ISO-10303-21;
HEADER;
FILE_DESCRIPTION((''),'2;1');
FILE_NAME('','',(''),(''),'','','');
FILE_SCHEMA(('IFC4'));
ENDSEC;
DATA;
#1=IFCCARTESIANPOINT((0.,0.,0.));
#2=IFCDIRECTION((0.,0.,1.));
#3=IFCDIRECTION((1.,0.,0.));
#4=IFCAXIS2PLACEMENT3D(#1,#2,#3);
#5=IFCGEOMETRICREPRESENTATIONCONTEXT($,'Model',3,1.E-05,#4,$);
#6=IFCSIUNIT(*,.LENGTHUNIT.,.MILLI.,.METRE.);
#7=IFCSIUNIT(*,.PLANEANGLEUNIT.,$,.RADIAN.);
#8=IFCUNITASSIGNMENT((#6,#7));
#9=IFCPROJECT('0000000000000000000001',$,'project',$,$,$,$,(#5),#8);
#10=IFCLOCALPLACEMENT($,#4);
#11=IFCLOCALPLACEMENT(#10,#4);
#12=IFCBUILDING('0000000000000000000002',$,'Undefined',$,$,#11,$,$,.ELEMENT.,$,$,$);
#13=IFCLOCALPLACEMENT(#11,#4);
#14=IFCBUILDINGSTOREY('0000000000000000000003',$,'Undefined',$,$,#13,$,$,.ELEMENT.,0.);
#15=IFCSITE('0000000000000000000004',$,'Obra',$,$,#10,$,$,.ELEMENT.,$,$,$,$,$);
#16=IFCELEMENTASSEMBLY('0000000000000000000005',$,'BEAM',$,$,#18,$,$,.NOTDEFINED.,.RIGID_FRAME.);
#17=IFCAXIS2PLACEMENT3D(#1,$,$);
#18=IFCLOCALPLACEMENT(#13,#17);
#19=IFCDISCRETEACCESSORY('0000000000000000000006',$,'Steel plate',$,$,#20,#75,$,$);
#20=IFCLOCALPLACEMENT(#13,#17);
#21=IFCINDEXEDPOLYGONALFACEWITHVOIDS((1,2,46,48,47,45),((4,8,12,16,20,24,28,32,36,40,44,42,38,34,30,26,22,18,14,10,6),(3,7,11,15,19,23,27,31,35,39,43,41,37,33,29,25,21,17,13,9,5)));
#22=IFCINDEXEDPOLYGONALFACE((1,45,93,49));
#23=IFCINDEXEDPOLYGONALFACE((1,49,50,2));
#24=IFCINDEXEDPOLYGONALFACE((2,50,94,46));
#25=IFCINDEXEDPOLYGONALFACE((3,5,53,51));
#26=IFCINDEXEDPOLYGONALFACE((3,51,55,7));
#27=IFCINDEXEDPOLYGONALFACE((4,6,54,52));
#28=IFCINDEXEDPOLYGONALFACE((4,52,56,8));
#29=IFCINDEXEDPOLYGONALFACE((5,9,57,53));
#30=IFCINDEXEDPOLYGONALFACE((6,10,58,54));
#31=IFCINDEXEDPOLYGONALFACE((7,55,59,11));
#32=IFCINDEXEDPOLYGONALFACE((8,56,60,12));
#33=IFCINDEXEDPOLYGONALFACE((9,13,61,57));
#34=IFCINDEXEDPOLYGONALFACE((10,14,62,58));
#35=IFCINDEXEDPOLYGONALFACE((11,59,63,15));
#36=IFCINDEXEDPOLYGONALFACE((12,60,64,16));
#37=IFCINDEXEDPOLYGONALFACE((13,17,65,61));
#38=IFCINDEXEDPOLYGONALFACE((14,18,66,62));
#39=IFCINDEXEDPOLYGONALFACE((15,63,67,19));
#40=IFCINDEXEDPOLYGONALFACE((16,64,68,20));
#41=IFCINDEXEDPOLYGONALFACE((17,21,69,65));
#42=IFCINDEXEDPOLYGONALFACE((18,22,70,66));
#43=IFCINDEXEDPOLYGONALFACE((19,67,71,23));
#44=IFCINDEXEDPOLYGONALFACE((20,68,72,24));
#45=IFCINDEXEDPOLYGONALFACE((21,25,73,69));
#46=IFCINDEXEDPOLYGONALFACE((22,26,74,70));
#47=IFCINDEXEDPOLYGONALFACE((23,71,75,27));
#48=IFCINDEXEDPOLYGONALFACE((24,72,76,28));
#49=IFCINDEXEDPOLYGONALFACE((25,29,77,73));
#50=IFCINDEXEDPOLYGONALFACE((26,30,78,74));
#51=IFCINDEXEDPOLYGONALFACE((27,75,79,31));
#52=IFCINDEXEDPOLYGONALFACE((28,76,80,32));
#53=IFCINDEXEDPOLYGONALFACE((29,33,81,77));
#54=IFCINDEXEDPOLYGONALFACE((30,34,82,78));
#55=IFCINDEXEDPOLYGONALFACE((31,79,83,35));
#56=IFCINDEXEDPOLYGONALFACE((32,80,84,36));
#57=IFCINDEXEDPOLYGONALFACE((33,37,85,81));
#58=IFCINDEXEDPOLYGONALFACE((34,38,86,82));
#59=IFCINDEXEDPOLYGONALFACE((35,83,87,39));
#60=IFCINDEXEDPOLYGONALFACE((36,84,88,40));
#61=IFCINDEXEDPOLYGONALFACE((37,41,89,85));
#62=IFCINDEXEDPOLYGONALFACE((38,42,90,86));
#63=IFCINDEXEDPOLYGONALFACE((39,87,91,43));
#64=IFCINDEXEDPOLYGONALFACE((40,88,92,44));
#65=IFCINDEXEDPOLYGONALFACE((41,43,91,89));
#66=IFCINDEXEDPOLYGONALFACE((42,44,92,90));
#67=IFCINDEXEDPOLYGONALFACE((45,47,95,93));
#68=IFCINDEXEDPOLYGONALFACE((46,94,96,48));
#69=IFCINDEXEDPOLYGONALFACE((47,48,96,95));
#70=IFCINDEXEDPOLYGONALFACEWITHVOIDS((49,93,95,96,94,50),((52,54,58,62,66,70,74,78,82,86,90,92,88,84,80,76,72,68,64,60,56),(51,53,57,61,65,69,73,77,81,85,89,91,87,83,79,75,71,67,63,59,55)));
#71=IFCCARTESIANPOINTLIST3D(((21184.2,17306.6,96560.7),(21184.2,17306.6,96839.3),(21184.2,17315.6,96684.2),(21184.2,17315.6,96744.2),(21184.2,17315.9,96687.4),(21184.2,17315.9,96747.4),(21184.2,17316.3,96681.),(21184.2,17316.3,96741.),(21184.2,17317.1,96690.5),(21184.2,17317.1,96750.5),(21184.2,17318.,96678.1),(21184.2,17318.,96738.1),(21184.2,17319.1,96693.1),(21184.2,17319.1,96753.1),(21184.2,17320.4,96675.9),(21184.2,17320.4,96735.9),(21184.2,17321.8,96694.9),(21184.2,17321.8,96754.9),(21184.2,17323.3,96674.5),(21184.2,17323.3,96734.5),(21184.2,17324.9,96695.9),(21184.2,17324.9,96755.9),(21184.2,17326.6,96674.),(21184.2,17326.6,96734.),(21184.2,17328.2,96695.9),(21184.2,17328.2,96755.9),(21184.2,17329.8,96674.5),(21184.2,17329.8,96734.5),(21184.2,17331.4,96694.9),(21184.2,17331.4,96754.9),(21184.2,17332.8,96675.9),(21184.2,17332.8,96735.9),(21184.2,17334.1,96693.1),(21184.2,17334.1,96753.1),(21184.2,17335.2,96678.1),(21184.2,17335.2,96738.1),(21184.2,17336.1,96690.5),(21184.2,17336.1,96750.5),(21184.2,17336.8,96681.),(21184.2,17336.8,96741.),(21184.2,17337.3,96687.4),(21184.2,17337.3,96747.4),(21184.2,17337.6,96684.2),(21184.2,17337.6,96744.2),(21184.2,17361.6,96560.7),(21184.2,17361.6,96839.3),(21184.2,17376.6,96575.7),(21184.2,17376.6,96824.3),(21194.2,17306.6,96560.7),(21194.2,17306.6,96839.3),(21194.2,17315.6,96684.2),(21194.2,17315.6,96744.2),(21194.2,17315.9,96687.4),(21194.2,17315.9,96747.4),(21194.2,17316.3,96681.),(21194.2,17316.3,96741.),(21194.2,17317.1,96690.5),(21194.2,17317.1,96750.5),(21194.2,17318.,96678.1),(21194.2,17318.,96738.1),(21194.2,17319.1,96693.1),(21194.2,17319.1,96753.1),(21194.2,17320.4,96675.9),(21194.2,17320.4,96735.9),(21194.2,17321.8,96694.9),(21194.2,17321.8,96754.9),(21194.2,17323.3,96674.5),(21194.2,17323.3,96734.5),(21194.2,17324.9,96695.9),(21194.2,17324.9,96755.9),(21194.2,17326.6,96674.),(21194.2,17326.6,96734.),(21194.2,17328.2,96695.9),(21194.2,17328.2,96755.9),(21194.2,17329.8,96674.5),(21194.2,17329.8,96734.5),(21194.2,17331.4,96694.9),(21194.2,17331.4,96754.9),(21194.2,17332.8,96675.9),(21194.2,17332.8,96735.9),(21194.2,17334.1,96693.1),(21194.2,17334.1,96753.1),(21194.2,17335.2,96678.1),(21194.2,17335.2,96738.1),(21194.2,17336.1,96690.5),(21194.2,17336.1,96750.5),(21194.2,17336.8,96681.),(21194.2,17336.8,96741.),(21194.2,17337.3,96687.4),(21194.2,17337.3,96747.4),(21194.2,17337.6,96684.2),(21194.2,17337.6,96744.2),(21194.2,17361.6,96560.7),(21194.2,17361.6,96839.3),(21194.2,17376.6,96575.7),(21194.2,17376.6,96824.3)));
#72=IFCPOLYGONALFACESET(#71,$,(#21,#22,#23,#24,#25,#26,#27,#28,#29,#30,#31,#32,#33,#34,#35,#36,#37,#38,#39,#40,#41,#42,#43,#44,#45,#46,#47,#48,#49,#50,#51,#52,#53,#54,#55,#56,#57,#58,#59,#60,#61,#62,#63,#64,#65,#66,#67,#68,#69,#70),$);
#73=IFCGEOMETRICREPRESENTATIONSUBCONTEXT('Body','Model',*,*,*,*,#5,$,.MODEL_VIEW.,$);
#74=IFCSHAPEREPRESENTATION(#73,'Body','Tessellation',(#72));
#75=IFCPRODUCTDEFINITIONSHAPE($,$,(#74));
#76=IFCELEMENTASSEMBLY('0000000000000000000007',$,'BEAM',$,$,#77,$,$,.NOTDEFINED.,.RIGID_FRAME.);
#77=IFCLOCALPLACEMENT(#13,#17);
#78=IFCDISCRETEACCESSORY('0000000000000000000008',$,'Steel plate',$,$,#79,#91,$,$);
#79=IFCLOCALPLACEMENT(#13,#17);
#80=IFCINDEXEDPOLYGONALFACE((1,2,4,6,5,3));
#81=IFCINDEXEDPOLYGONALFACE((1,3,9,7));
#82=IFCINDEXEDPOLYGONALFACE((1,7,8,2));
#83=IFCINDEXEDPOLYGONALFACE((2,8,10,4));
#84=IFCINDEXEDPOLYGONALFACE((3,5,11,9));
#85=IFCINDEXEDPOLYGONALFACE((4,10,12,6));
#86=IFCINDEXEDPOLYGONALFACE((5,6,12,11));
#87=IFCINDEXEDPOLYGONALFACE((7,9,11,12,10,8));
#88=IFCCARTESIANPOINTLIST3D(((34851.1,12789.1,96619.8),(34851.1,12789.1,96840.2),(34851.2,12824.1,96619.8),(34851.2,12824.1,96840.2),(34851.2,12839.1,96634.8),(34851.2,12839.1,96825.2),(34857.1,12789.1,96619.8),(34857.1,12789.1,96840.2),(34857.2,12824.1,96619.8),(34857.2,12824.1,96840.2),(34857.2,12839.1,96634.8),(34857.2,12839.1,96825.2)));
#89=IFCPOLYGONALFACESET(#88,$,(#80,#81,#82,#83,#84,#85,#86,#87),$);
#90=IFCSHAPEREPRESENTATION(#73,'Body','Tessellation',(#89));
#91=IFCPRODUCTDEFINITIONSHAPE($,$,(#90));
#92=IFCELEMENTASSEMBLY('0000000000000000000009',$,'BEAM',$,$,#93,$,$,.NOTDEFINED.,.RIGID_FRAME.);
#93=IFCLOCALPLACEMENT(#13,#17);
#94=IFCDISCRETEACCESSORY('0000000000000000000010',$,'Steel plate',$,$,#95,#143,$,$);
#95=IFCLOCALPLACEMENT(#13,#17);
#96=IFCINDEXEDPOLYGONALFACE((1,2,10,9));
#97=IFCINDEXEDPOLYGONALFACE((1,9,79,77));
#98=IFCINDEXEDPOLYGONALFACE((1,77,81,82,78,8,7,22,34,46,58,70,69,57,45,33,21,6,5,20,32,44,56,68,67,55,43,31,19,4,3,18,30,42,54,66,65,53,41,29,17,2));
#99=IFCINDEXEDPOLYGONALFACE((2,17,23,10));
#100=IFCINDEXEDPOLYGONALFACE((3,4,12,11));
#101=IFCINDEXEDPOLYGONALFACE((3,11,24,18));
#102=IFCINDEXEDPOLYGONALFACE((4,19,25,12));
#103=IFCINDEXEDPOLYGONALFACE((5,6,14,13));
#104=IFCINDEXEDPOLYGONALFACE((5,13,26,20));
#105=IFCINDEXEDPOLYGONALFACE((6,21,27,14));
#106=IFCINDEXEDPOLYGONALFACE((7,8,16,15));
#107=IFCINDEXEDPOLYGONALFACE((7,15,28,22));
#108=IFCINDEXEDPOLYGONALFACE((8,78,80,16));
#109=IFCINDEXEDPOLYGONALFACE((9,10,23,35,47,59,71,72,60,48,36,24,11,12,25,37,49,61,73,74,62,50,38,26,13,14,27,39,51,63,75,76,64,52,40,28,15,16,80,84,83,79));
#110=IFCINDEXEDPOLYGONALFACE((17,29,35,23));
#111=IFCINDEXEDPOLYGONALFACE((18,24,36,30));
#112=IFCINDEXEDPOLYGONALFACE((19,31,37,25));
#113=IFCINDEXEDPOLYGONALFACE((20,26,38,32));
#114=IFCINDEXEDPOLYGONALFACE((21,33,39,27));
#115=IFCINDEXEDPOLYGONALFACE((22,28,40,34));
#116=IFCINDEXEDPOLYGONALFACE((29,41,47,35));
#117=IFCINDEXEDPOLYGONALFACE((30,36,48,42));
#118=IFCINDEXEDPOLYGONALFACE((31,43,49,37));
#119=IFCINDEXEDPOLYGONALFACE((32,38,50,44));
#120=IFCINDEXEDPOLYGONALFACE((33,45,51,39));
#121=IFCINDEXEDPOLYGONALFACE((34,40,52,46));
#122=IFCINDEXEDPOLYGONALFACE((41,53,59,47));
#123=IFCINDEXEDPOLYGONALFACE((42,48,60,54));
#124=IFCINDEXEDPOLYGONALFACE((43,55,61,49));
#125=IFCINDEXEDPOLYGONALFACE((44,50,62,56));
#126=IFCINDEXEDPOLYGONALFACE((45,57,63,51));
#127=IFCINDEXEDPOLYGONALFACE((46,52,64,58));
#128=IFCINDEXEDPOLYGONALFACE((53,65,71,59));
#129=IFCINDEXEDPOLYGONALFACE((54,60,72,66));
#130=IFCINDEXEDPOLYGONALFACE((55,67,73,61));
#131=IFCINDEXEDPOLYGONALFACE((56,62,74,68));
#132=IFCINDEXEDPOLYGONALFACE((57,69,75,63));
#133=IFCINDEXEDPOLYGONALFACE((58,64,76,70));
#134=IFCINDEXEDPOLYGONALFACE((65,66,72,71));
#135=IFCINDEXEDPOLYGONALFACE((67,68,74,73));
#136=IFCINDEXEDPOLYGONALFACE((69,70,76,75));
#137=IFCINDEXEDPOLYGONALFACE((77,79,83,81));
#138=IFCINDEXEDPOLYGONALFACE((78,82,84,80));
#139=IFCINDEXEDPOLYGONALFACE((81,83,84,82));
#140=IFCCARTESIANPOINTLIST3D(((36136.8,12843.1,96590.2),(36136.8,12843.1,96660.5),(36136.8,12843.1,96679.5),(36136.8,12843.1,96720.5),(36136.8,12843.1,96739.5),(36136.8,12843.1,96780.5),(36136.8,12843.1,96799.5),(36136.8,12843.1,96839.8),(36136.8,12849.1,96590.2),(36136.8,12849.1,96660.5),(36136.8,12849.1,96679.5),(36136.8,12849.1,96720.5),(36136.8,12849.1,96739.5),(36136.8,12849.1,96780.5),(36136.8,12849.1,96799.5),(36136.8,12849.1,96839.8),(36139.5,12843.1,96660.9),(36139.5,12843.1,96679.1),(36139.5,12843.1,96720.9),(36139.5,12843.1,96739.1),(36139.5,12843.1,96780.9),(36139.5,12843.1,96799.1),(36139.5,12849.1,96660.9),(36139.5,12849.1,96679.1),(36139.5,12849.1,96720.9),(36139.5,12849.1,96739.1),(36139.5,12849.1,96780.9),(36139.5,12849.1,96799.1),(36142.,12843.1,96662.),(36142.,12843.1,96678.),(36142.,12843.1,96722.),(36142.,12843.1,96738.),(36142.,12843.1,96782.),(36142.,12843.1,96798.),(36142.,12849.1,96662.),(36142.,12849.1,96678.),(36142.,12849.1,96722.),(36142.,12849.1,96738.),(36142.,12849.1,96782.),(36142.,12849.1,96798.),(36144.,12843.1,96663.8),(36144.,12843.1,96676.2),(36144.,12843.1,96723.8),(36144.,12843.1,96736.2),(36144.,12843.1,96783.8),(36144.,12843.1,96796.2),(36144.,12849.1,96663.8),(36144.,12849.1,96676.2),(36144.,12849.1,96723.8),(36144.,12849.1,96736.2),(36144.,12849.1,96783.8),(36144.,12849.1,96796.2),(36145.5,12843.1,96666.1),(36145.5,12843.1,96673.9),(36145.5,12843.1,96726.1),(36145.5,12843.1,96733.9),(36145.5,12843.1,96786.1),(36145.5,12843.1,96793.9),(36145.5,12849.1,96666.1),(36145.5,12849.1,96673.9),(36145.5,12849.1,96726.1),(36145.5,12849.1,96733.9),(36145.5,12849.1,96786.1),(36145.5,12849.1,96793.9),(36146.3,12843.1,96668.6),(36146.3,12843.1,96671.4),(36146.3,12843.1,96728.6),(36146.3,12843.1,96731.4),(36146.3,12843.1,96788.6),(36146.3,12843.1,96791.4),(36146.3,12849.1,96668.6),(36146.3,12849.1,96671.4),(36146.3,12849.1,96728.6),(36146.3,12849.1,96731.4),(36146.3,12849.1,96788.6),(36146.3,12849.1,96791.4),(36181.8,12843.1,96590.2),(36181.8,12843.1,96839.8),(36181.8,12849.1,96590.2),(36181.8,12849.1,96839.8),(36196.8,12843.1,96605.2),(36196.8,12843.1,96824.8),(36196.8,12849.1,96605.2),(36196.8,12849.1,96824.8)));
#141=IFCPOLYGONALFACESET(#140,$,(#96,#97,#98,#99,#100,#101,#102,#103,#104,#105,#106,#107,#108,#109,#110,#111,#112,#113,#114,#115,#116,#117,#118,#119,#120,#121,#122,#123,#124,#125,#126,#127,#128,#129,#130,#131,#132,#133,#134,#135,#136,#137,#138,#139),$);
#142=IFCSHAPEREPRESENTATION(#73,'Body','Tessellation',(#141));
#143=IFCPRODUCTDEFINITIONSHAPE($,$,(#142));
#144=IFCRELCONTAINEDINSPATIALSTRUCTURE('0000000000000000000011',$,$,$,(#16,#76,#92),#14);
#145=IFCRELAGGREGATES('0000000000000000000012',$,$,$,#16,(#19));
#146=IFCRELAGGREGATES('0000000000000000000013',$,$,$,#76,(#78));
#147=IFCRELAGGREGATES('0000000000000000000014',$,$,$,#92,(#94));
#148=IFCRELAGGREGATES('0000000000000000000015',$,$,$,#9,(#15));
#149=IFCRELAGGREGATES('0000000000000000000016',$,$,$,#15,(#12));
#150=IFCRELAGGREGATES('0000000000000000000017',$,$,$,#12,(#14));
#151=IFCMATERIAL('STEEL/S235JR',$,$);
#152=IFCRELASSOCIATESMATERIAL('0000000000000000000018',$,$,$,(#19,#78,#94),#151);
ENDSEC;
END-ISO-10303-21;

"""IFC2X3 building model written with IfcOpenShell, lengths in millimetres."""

from ifc_helpers import new_model, si_unit, frame, origin_with_axes, origin_2d_with_axis, place, context, subcontext, project, spatial, polyline, circle, outline, extrude, source, transform, mapped, material, element, aggregate, save


model = new_model("IFC2X3")

# Units and contexts
model_context = context("Model", 3, precision=1e-05, world=origin_with_axes())
body_context = subcontext(model_context, "Body", "Model", "MODEL_VIEW")
ifc_project = project(units=[si_unit("LENGTHUNIT", "METRE", prefix="MILLI"), si_unit("PLANEANGLEUNIT", "RADIAN")], contexts=[model_context])

# Site, building, storey
site_placement = place(None, origin_with_axes())
site = spatial("IfcSite", under=ifc_project, at=site_placement, Name="Obra", CompositionType="ELEMENT")
building_placement = place(site_placement, origin_with_axes())
building = spatial("IfcBuilding", under=site, at=building_placement, Name="Undefined", CompositionType="ELEMENT")
storey_placement = place(building_placement, origin_with_axes())
storey = spatial("IfcBuildingStorey", under=building, at=storey_placement, Name="Undefined", CompositionType="ELEMENT", Elevation=0.0)

# Shared definitions
ifc_material = material(Name="STEEL/S235JR")

# Shared definitions
shared_shape_1 = source(origin_with_axes(), body_context, "Body", "SweptSolid", [
    extrude(circle(Radius=9.5, at=origin_2d_with_axis()), frame((0.0, -9.2, 0.0), z_axis=(0.0, 1.0, 0.0), x_axis=(1.0, 0.0, 0.0)), (0.0, 0.0, 1.0), 6.2),
])

# Shared definitions
shared_shape_2 = source(origin_with_axes(), body_context, "Body", "SweptSolid", [
    extrude(circle(Radius=11.0, at=origin_2d_with_axis()), frame((0.0, -13.4, 0.0), z_axis=(0.0, 1.0, 0.0), x_axis=(1.0, 0.0, 0.0)), (0.0, 0.0, 1.0), 10.2),
])

# Element assembly
assembly_1_placement = place(storey_placement, origin_with_axes())
assembly_1 = element("IfcElementAssembly", 1, at=assembly_1_placement, inside=storey, Name="BEAM", AssemblyPlace="NOTDEFINED", PredefinedType="RIGID_FRAME")

# Discrete accessory, opening
discrete_accessory_1_placement = place(assembly_1_placement, frame((21189.2, 17306.6, 96560.7), z_axis=(1.0, 0.0, 0.0), x_axis=(0.0, 1.0, 0.0)))
discrete_accessory_1 = element("IfcDiscreteAccessory", 2, at=discrete_accessory_1_placement, material=ifc_material, Name="Steel plate", context=body_context, shape_type="SweptSolid", body=[
    extrude(outline(polyline([(0.0, 0.0), (55.0, 0.0), (70.0, 15.0), (70.0, 263.6), (55.0, 278.6), (0.0, 278.6), (0.0, 0.0)])), frame((0.0, 0.0, -5.0), z_axis=(0.0, 0.0, 1.0), x_axis=(1.0, 0.0, 0.0)), (0.0, 0.0, 1.0), 10.0),
])
opening_1_placement = place(assembly_1_placement, frame((21197.5, 17366.6, 96850.0), z_axis=(0.0, -1.0, 0.0), x_axis=(0.0, 0.0, -1.0)))
element("IfcOpeningElement", 3, at=opening_1_placement, cuts=discrete_accessory_1, ObjectType="Opening", context=body_context, shape_type="MappedRepresentation", body=[
    mapped(shared_shape_2, transform((105.0, 0.0, 40.0))),
    mapped(shared_shape_2, transform((165.0, 0.0, 40.0))),
])
aggregate(assembly_1, [discrete_accessory_1])

# Element assembly, discrete accessory
assembly_2_placement = place(storey_placement, origin_with_axes())
assembly_2 = element("IfcElementAssembly", 4, at=assembly_2_placement, inside=storey, Name="BEAM", AssemblyPlace="NOTDEFINED", PredefinedType="RIGID_FRAME")
discrete_accessory_2_placement = place(assembly_2_placement, frame((34854.1, 12789.1, 96619.8), z_axis=(0.999999, -0.001625, 0.0), x_axis=(0.001625, 0.999999, 0.0)))
discrete_accessory_2 = element("IfcDiscreteAccessory", 5, at=discrete_accessory_2_placement, material=ifc_material, Name="Steel plate", context=body_context, shape_type="SweptSolid", body=[
    extrude(outline(polyline([(0.0, 0.0), (35.0, 0.0), (50.0, 15.0), (50.0, 205.4), (35.0, 220.4), (0.0, 220.4), (0.0, 0.0)])), frame((0.0, 0.0, -3.0), z_axis=(0.0, 0.0, 1.0), x_axis=(1.0, 0.0, 0.0)), (0.0, 0.0, 1.0), 6.0),
])
aggregate(assembly_2, [discrete_accessory_2])

# Element assembly, discrete accessory, opening
assembly_3_placement = place(storey_placement, origin_with_axes())
assembly_3 = element("IfcElementAssembly", 6, at=assembly_3_placement, inside=storey, Name="BEAM", AssemblyPlace="NOTDEFINED", PredefinedType="RIGID_FRAME")
discrete_accessory_3_placement = place(assembly_3_placement, frame((36136.8, 12846.1, 96590.2), z_axis=(0.0, -1.0, 0.0), x_axis=(1.0, 0.0, 0.0)))
discrete_accessory_3 = element("IfcDiscreteAccessory", 7, at=discrete_accessory_3_placement, material=ifc_material, Name="Steel plate", context=body_context, shape_type="SweptSolid", body=[
    extrude(outline(polyline([(0.0, 0.0), (45.0, 0.0), (60.0, 15.0), (60.0, 234.6), (45.0, 249.6), (0.0, 249.6), (0.0, 0.0)])), frame((0.0, 0.0, -3.0), z_axis=(0.0, 0.0, 1.0), x_axis=(1.0, 0.0, 0.0)), (0.0, 0.0, 1.0), 6.0),
])
opening_2_placement = place(assembly_3_placement, frame((36186.8, 12840.0, 96850.0), z_axis=(-1.0, 0.0, 0.0), x_axis=(0.0, 0.0, -1.0)))
element("IfcOpeningElement", 8, at=opening_2_placement, cuts=discrete_accessory_3, ObjectType="Opening", context=body_context, shape_type="MappedRepresentation", body=[
    mapped(shared_shape_1, transform((60.0, 0.0, 50.0))),
    mapped(shared_shape_1, transform((120.0, 0.0, 50.0))),
    mapped(shared_shape_1, transform((180.0, 0.0, 50.0))),
])
aggregate(assembly_3, [discrete_accessory_3])

save(model, "model.ifc")
